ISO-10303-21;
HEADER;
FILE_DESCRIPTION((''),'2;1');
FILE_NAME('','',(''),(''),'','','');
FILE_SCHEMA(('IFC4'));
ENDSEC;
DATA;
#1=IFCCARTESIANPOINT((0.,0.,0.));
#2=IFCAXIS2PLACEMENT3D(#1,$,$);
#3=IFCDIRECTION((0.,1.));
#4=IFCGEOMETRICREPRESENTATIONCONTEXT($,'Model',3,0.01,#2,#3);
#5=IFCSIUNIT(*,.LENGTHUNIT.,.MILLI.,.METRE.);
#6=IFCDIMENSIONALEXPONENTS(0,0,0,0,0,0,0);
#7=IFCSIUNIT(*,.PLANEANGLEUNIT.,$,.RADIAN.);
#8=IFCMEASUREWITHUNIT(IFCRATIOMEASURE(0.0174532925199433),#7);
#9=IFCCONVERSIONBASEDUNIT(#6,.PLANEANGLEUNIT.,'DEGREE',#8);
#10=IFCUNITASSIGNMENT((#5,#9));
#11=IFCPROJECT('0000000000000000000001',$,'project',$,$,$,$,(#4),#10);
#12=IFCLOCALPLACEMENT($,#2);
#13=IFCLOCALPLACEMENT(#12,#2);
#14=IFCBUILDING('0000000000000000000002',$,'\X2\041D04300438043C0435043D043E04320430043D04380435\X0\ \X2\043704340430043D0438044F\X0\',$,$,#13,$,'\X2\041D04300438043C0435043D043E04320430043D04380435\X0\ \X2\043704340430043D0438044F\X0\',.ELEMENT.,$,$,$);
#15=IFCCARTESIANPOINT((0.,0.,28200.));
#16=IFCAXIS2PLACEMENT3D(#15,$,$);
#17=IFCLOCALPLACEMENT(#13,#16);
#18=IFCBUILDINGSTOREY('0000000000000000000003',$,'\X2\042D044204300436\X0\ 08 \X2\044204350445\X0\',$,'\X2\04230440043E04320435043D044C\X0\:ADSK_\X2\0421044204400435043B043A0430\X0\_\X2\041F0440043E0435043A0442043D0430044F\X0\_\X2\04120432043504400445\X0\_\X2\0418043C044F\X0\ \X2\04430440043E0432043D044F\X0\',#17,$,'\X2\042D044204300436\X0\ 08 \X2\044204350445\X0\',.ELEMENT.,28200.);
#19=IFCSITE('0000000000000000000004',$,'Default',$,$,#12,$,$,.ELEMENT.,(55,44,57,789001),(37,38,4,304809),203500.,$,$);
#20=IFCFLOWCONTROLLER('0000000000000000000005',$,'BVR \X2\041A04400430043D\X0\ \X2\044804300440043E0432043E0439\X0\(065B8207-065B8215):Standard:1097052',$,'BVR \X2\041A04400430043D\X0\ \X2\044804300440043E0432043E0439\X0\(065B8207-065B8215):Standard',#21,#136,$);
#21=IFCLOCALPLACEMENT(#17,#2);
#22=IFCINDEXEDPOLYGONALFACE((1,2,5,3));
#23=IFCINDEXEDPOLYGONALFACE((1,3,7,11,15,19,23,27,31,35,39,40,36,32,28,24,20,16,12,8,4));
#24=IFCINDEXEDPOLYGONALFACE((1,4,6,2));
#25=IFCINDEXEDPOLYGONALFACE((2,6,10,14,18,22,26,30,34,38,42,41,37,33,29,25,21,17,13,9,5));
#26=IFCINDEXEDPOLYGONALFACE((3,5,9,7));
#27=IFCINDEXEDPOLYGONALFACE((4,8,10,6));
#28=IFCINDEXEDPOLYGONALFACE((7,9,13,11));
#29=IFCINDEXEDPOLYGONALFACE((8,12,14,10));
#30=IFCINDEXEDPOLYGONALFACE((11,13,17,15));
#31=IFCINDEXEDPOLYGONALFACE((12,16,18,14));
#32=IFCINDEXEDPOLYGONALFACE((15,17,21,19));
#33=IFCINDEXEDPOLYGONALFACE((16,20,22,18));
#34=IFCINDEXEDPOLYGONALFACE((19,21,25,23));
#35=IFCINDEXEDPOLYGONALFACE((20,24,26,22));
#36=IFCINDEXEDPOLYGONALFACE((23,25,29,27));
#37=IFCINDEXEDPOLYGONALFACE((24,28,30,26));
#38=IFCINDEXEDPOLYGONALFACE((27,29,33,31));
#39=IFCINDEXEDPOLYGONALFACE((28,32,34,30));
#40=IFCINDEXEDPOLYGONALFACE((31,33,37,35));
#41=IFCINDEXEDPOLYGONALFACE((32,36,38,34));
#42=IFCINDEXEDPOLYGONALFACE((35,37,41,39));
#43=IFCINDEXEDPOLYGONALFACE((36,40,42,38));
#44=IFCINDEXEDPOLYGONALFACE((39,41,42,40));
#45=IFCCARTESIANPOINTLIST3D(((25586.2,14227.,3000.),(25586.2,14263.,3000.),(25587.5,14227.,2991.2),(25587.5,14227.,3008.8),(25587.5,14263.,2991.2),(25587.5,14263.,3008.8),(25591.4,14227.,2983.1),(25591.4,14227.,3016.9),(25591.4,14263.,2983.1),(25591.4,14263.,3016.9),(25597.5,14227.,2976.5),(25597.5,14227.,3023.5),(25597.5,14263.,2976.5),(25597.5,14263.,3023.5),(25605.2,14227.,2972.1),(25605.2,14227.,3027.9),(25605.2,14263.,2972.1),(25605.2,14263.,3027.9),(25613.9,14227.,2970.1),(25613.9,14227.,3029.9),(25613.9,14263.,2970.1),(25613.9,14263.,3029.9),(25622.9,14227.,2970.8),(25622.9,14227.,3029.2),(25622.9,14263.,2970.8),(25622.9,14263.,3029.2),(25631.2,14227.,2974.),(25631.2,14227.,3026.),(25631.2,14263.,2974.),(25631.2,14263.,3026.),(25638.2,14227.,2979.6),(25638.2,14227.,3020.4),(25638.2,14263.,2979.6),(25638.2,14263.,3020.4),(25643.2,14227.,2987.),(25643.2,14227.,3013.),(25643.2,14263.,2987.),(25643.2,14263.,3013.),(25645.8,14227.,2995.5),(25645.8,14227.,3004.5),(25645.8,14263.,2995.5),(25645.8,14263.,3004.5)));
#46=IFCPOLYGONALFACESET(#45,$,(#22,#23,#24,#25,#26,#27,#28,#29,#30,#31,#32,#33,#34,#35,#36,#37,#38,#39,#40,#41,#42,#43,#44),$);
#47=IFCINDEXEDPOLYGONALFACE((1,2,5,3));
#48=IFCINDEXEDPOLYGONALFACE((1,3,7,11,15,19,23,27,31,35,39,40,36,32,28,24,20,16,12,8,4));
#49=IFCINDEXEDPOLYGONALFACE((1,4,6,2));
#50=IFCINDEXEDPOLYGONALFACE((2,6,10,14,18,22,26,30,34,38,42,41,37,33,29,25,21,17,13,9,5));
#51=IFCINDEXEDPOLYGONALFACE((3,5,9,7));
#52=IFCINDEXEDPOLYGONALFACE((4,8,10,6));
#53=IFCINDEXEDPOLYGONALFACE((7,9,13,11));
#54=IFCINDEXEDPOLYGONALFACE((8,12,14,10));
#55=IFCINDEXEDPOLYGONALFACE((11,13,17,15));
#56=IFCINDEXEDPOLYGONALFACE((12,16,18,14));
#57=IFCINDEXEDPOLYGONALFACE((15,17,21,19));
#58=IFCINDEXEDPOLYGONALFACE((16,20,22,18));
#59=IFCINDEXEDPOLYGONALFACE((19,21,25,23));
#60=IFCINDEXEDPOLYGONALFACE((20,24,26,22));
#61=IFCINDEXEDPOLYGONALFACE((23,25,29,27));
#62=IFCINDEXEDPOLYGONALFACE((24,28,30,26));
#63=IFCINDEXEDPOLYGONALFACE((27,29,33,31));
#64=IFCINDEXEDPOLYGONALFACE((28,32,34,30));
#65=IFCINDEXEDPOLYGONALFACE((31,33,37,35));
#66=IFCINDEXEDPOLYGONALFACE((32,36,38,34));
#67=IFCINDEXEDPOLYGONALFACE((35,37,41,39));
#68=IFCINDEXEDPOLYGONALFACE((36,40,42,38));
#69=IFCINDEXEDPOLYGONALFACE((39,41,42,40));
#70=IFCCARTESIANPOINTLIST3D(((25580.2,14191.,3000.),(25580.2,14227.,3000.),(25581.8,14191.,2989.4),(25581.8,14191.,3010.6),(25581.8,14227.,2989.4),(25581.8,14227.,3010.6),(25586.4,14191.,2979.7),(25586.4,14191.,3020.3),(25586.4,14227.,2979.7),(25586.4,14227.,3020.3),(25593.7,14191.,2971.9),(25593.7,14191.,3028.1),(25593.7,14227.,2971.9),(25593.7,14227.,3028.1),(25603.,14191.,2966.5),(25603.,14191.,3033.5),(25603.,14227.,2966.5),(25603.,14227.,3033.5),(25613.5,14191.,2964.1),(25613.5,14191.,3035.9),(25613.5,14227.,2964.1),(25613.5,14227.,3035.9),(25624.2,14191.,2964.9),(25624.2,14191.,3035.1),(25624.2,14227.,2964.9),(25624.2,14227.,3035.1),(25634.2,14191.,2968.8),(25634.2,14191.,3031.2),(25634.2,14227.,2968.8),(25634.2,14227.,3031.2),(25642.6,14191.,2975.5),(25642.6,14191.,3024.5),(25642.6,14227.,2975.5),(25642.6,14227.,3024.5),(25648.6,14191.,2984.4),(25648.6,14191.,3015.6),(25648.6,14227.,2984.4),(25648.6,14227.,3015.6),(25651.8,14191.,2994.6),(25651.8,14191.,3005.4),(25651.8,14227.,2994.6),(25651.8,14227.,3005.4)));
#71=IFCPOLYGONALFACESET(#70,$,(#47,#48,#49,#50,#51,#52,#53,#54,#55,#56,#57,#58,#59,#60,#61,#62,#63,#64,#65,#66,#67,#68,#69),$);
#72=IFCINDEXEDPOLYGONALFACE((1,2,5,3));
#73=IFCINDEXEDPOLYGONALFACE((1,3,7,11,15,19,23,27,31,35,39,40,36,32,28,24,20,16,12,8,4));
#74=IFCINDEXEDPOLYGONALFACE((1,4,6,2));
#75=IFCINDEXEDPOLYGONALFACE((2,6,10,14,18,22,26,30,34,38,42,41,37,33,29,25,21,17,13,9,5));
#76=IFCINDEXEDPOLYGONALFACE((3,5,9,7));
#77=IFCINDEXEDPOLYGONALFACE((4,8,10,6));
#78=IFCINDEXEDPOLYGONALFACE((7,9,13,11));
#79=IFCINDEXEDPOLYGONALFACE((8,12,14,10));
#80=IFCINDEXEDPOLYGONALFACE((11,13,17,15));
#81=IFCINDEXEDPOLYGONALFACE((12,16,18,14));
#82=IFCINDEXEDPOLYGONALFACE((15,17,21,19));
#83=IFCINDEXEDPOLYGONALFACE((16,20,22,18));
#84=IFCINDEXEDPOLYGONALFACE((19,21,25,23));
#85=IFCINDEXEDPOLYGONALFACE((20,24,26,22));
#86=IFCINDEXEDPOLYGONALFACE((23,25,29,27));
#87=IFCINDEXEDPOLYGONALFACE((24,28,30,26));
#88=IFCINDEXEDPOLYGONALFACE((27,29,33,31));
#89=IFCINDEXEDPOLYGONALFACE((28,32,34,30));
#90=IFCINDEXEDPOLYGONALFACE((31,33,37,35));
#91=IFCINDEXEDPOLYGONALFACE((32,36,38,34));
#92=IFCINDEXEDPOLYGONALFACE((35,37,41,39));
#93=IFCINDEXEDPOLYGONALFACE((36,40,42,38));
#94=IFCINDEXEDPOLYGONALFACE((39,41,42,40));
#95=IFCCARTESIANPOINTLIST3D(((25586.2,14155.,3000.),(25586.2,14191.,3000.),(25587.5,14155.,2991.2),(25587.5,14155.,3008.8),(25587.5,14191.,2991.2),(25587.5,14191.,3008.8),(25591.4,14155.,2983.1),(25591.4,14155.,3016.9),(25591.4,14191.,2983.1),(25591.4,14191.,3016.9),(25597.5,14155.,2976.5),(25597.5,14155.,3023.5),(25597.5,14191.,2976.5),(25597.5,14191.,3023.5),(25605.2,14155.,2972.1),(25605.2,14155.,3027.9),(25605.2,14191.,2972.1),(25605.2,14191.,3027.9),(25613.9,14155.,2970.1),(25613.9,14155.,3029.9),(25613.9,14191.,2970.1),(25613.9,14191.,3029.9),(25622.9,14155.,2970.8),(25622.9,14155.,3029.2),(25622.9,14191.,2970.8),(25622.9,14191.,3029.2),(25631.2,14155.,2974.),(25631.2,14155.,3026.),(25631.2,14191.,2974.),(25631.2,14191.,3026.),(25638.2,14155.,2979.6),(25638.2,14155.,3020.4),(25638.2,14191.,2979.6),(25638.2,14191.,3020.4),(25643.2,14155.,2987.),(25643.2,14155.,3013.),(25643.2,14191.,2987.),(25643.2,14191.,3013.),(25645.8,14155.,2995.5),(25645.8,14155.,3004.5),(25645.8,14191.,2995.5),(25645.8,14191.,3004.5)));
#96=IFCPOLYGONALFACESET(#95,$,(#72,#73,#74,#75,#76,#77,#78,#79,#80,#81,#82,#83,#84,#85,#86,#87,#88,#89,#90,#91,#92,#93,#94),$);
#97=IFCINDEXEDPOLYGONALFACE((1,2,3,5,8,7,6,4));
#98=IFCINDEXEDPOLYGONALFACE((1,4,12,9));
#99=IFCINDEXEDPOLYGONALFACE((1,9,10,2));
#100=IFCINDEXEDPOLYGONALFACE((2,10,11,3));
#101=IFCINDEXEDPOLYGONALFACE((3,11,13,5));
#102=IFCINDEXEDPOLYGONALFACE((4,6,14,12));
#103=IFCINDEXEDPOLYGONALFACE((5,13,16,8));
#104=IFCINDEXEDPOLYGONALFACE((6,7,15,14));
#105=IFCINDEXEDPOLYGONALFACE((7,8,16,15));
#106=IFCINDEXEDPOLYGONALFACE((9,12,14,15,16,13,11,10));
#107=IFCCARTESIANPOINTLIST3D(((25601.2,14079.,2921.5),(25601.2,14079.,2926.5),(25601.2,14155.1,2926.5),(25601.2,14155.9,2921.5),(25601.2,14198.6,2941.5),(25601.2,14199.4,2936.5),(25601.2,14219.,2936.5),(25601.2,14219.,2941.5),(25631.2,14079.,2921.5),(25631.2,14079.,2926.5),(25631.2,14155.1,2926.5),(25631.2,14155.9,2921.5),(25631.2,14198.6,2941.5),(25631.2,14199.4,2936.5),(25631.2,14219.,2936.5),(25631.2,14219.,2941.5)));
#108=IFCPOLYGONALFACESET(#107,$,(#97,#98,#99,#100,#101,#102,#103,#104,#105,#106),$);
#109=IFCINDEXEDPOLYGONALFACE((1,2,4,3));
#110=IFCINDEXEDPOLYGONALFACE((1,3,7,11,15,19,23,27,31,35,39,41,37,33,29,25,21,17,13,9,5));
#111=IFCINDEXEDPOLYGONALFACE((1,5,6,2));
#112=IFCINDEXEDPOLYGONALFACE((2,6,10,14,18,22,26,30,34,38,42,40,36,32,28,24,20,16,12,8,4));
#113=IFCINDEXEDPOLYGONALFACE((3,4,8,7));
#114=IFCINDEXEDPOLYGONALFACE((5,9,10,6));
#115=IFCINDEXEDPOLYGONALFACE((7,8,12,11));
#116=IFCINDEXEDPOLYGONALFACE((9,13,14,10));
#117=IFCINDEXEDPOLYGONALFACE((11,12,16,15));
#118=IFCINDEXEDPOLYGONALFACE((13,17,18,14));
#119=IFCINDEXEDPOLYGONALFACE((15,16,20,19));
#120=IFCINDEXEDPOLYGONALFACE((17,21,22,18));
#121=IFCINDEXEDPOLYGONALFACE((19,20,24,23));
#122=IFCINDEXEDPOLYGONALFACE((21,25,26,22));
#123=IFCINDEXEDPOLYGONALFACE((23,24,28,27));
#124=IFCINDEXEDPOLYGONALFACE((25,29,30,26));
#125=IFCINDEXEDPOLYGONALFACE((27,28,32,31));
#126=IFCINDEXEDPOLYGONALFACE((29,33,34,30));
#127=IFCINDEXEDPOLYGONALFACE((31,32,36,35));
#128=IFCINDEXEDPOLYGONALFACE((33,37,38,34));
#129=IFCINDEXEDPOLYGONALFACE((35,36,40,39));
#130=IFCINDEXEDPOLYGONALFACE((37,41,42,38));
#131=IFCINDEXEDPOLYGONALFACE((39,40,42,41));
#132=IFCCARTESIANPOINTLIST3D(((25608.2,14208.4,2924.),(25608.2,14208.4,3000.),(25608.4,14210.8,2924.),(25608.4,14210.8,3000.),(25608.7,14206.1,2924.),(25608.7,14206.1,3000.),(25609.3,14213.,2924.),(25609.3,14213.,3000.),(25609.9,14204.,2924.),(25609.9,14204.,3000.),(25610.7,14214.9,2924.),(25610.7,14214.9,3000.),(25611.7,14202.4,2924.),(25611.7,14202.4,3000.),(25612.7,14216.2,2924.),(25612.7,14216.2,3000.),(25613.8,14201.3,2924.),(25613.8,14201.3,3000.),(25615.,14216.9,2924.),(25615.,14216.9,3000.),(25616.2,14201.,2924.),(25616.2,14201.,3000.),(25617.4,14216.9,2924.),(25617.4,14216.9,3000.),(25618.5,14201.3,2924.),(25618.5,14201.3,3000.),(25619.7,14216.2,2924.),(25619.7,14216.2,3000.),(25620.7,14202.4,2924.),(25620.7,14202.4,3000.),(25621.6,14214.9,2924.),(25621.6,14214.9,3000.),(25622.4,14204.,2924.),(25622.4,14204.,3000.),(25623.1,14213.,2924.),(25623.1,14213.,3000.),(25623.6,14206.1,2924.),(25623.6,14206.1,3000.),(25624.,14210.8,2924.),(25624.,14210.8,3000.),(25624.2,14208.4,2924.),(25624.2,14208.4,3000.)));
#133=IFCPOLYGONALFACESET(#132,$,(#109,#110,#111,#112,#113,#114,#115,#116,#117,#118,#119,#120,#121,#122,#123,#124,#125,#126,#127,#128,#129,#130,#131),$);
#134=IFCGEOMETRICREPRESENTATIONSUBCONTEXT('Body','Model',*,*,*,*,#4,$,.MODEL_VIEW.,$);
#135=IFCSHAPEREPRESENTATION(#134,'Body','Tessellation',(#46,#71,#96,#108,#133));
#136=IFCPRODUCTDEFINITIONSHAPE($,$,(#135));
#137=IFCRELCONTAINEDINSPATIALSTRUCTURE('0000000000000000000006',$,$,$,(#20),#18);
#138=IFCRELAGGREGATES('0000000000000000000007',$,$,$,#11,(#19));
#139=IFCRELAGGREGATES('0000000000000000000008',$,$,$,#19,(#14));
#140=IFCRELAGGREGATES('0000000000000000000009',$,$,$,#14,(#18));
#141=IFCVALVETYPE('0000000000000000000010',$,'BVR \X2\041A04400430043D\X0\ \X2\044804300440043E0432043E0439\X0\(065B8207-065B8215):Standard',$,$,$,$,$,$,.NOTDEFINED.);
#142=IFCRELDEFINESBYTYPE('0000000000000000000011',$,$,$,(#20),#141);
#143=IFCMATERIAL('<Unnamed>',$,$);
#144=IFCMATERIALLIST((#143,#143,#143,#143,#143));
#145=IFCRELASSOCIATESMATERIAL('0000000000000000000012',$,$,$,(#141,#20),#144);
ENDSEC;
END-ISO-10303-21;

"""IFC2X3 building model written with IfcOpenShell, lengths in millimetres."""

from ifc_helpers import new_model, entity, si_unit, converted_unit, direction, frame, origin, origin_2d_with_axis, place, context, subcontext, project, spatial, polyline, circle, outline, extrude, source, transform, mapped, material, material_list, type_object, type_shapes, element, save


model = new_model("IFC2X3")

# Units and contexts
model_context = context("Model", 3, precision=0.01, world=origin(), true_north=direction((0.0, 1.0)))
body_context = subcontext(model_context, "Body", "Model", "MODEL_VIEW")
ifc_project = project(units=[si_unit("LENGTHUNIT", "METRE", prefix="MILLI"), converted_unit("PLANEANGLEUNIT", "DEGREE", entity("IfcRatioMeasure", 0.0174532925199433), si_unit("PLANEANGLEUNIT", "RADIAN"), dimensions=[0, 0, 0, 0, 0, 0, 0])], contexts=[model_context])

# Site, building, storey
site_placement = place(None, origin())
site = spatial("IfcSite", under=ifc_project, at=site_placement, Name="Default", CompositionType="ELEMENT", RefLatitude=(55, 44, 57, 789001), RefLongitude=(37, 38, 4, 304809), RefElevation=203500.0)
building_placement = place(site_placement, origin())
building = spatial("IfcBuilding", under=site, at=building_placement, Name="Наименование здания", LongName="Наименование здания", CompositionType="ELEMENT")
storey_placement = place(building_placement, frame((0.0, 0.0, 28200.0)))
storey = spatial("IfcBuildingStorey", under=building, at=storey_placement, Name="Этаж 08 тех", ObjectType="Уровень:ADSK_Стрелка_Проектная_Вверх_Имя уровня", LongName="Этаж 08 тех", CompositionType="ELEMENT", Elevation=28200.0)

# Shared definitions
ifc_material = material(Name="<Unnamed>")
ifc_material_list_1 = material_list([ifc_material, ifc_material, ifc_material, ifc_material, ifc_material])

# Flow controller
valve_type_1 = type_object("IfcValveType", Name="BVR Кран шаровой(065B8207-065B8215):Standard", PredefinedType="NOTDEFINED", material=ifc_material_list_1)
shared_shape_1 = source(origin(), body_context, "Body", "SweptSolid", [
    extrude(circle(Radius=30.0, at=origin_2d_with_axis()), frame((-54.0, 0.0, 0.0), z_axis=(1.0, 0.0, 0.0), x_axis=(0.0, 1.0, 0.0)), (0.0, 0.0, 1.0), 36.0),
    extrude(circle(Radius=36.0, at=origin_2d_with_axis()), frame((-18.0, 0.0, 0.0), z_axis=(1.0, 0.0, 0.0), x_axis=(0.0, 1.0, 0.0)), (0.0, 0.0, 1.0), 36.0),
    extrude(circle(Radius=30.0, at=origin_2d_with_axis()), frame((18.0, 0.0, 0.0), z_axis=(1.0, 0.0, 0.0), x_axis=(0.0, 1.0, 0.0)), (0.0, 0.0, 1.0), 36.0),
    extrude(outline(polyline([(-55.9, -5.0), (-55.9, -10.0), (-35.5, -10.0), (8.0, 5.0), (84.1, 5.0), (84.1, 10.0), (7.2, 10.0), (-36.3, -5.0), (-55.9, -5.0)])), frame((45.9, -15.0, 68.5), z_axis=(0.0, -1.0, 0.0), x_axis=(1.0, 0.0, 0.0)), (0.0, 0.0, -1.0), 30.0),
    extrude(circle(Radius=8.0, at=origin_2d_with_axis()), origin(), (0.0, 0.0, 1.0), 76.0),
])
type_shapes(valve_type_1, [shared_shape_1])
flow_controller_1_placement = place(storey_placement, frame((25616.2, 14209.0, 3000.0), z_axis=(0.0, 0.0, -1.0), x_axis=(0.0, -1.0, 0.0)))
element("IfcFlowController", 1, at=flow_controller_1_placement, inside=storey, type_object=valve_type_1, material=ifc_material_list_1, Name="BVR Кран шаровой(065B8207-065B8215):Standard:1097052", ObjectType="BVR Кран шаровой(065B8207-065B8215):Standard", context=body_context, shape_type="MappedRepresentation", body=[
    mapped(shared_shape_1, transform((0.0, 0.0, 0.0), scale=1.0)),
])

save(model, "model.ifc")
